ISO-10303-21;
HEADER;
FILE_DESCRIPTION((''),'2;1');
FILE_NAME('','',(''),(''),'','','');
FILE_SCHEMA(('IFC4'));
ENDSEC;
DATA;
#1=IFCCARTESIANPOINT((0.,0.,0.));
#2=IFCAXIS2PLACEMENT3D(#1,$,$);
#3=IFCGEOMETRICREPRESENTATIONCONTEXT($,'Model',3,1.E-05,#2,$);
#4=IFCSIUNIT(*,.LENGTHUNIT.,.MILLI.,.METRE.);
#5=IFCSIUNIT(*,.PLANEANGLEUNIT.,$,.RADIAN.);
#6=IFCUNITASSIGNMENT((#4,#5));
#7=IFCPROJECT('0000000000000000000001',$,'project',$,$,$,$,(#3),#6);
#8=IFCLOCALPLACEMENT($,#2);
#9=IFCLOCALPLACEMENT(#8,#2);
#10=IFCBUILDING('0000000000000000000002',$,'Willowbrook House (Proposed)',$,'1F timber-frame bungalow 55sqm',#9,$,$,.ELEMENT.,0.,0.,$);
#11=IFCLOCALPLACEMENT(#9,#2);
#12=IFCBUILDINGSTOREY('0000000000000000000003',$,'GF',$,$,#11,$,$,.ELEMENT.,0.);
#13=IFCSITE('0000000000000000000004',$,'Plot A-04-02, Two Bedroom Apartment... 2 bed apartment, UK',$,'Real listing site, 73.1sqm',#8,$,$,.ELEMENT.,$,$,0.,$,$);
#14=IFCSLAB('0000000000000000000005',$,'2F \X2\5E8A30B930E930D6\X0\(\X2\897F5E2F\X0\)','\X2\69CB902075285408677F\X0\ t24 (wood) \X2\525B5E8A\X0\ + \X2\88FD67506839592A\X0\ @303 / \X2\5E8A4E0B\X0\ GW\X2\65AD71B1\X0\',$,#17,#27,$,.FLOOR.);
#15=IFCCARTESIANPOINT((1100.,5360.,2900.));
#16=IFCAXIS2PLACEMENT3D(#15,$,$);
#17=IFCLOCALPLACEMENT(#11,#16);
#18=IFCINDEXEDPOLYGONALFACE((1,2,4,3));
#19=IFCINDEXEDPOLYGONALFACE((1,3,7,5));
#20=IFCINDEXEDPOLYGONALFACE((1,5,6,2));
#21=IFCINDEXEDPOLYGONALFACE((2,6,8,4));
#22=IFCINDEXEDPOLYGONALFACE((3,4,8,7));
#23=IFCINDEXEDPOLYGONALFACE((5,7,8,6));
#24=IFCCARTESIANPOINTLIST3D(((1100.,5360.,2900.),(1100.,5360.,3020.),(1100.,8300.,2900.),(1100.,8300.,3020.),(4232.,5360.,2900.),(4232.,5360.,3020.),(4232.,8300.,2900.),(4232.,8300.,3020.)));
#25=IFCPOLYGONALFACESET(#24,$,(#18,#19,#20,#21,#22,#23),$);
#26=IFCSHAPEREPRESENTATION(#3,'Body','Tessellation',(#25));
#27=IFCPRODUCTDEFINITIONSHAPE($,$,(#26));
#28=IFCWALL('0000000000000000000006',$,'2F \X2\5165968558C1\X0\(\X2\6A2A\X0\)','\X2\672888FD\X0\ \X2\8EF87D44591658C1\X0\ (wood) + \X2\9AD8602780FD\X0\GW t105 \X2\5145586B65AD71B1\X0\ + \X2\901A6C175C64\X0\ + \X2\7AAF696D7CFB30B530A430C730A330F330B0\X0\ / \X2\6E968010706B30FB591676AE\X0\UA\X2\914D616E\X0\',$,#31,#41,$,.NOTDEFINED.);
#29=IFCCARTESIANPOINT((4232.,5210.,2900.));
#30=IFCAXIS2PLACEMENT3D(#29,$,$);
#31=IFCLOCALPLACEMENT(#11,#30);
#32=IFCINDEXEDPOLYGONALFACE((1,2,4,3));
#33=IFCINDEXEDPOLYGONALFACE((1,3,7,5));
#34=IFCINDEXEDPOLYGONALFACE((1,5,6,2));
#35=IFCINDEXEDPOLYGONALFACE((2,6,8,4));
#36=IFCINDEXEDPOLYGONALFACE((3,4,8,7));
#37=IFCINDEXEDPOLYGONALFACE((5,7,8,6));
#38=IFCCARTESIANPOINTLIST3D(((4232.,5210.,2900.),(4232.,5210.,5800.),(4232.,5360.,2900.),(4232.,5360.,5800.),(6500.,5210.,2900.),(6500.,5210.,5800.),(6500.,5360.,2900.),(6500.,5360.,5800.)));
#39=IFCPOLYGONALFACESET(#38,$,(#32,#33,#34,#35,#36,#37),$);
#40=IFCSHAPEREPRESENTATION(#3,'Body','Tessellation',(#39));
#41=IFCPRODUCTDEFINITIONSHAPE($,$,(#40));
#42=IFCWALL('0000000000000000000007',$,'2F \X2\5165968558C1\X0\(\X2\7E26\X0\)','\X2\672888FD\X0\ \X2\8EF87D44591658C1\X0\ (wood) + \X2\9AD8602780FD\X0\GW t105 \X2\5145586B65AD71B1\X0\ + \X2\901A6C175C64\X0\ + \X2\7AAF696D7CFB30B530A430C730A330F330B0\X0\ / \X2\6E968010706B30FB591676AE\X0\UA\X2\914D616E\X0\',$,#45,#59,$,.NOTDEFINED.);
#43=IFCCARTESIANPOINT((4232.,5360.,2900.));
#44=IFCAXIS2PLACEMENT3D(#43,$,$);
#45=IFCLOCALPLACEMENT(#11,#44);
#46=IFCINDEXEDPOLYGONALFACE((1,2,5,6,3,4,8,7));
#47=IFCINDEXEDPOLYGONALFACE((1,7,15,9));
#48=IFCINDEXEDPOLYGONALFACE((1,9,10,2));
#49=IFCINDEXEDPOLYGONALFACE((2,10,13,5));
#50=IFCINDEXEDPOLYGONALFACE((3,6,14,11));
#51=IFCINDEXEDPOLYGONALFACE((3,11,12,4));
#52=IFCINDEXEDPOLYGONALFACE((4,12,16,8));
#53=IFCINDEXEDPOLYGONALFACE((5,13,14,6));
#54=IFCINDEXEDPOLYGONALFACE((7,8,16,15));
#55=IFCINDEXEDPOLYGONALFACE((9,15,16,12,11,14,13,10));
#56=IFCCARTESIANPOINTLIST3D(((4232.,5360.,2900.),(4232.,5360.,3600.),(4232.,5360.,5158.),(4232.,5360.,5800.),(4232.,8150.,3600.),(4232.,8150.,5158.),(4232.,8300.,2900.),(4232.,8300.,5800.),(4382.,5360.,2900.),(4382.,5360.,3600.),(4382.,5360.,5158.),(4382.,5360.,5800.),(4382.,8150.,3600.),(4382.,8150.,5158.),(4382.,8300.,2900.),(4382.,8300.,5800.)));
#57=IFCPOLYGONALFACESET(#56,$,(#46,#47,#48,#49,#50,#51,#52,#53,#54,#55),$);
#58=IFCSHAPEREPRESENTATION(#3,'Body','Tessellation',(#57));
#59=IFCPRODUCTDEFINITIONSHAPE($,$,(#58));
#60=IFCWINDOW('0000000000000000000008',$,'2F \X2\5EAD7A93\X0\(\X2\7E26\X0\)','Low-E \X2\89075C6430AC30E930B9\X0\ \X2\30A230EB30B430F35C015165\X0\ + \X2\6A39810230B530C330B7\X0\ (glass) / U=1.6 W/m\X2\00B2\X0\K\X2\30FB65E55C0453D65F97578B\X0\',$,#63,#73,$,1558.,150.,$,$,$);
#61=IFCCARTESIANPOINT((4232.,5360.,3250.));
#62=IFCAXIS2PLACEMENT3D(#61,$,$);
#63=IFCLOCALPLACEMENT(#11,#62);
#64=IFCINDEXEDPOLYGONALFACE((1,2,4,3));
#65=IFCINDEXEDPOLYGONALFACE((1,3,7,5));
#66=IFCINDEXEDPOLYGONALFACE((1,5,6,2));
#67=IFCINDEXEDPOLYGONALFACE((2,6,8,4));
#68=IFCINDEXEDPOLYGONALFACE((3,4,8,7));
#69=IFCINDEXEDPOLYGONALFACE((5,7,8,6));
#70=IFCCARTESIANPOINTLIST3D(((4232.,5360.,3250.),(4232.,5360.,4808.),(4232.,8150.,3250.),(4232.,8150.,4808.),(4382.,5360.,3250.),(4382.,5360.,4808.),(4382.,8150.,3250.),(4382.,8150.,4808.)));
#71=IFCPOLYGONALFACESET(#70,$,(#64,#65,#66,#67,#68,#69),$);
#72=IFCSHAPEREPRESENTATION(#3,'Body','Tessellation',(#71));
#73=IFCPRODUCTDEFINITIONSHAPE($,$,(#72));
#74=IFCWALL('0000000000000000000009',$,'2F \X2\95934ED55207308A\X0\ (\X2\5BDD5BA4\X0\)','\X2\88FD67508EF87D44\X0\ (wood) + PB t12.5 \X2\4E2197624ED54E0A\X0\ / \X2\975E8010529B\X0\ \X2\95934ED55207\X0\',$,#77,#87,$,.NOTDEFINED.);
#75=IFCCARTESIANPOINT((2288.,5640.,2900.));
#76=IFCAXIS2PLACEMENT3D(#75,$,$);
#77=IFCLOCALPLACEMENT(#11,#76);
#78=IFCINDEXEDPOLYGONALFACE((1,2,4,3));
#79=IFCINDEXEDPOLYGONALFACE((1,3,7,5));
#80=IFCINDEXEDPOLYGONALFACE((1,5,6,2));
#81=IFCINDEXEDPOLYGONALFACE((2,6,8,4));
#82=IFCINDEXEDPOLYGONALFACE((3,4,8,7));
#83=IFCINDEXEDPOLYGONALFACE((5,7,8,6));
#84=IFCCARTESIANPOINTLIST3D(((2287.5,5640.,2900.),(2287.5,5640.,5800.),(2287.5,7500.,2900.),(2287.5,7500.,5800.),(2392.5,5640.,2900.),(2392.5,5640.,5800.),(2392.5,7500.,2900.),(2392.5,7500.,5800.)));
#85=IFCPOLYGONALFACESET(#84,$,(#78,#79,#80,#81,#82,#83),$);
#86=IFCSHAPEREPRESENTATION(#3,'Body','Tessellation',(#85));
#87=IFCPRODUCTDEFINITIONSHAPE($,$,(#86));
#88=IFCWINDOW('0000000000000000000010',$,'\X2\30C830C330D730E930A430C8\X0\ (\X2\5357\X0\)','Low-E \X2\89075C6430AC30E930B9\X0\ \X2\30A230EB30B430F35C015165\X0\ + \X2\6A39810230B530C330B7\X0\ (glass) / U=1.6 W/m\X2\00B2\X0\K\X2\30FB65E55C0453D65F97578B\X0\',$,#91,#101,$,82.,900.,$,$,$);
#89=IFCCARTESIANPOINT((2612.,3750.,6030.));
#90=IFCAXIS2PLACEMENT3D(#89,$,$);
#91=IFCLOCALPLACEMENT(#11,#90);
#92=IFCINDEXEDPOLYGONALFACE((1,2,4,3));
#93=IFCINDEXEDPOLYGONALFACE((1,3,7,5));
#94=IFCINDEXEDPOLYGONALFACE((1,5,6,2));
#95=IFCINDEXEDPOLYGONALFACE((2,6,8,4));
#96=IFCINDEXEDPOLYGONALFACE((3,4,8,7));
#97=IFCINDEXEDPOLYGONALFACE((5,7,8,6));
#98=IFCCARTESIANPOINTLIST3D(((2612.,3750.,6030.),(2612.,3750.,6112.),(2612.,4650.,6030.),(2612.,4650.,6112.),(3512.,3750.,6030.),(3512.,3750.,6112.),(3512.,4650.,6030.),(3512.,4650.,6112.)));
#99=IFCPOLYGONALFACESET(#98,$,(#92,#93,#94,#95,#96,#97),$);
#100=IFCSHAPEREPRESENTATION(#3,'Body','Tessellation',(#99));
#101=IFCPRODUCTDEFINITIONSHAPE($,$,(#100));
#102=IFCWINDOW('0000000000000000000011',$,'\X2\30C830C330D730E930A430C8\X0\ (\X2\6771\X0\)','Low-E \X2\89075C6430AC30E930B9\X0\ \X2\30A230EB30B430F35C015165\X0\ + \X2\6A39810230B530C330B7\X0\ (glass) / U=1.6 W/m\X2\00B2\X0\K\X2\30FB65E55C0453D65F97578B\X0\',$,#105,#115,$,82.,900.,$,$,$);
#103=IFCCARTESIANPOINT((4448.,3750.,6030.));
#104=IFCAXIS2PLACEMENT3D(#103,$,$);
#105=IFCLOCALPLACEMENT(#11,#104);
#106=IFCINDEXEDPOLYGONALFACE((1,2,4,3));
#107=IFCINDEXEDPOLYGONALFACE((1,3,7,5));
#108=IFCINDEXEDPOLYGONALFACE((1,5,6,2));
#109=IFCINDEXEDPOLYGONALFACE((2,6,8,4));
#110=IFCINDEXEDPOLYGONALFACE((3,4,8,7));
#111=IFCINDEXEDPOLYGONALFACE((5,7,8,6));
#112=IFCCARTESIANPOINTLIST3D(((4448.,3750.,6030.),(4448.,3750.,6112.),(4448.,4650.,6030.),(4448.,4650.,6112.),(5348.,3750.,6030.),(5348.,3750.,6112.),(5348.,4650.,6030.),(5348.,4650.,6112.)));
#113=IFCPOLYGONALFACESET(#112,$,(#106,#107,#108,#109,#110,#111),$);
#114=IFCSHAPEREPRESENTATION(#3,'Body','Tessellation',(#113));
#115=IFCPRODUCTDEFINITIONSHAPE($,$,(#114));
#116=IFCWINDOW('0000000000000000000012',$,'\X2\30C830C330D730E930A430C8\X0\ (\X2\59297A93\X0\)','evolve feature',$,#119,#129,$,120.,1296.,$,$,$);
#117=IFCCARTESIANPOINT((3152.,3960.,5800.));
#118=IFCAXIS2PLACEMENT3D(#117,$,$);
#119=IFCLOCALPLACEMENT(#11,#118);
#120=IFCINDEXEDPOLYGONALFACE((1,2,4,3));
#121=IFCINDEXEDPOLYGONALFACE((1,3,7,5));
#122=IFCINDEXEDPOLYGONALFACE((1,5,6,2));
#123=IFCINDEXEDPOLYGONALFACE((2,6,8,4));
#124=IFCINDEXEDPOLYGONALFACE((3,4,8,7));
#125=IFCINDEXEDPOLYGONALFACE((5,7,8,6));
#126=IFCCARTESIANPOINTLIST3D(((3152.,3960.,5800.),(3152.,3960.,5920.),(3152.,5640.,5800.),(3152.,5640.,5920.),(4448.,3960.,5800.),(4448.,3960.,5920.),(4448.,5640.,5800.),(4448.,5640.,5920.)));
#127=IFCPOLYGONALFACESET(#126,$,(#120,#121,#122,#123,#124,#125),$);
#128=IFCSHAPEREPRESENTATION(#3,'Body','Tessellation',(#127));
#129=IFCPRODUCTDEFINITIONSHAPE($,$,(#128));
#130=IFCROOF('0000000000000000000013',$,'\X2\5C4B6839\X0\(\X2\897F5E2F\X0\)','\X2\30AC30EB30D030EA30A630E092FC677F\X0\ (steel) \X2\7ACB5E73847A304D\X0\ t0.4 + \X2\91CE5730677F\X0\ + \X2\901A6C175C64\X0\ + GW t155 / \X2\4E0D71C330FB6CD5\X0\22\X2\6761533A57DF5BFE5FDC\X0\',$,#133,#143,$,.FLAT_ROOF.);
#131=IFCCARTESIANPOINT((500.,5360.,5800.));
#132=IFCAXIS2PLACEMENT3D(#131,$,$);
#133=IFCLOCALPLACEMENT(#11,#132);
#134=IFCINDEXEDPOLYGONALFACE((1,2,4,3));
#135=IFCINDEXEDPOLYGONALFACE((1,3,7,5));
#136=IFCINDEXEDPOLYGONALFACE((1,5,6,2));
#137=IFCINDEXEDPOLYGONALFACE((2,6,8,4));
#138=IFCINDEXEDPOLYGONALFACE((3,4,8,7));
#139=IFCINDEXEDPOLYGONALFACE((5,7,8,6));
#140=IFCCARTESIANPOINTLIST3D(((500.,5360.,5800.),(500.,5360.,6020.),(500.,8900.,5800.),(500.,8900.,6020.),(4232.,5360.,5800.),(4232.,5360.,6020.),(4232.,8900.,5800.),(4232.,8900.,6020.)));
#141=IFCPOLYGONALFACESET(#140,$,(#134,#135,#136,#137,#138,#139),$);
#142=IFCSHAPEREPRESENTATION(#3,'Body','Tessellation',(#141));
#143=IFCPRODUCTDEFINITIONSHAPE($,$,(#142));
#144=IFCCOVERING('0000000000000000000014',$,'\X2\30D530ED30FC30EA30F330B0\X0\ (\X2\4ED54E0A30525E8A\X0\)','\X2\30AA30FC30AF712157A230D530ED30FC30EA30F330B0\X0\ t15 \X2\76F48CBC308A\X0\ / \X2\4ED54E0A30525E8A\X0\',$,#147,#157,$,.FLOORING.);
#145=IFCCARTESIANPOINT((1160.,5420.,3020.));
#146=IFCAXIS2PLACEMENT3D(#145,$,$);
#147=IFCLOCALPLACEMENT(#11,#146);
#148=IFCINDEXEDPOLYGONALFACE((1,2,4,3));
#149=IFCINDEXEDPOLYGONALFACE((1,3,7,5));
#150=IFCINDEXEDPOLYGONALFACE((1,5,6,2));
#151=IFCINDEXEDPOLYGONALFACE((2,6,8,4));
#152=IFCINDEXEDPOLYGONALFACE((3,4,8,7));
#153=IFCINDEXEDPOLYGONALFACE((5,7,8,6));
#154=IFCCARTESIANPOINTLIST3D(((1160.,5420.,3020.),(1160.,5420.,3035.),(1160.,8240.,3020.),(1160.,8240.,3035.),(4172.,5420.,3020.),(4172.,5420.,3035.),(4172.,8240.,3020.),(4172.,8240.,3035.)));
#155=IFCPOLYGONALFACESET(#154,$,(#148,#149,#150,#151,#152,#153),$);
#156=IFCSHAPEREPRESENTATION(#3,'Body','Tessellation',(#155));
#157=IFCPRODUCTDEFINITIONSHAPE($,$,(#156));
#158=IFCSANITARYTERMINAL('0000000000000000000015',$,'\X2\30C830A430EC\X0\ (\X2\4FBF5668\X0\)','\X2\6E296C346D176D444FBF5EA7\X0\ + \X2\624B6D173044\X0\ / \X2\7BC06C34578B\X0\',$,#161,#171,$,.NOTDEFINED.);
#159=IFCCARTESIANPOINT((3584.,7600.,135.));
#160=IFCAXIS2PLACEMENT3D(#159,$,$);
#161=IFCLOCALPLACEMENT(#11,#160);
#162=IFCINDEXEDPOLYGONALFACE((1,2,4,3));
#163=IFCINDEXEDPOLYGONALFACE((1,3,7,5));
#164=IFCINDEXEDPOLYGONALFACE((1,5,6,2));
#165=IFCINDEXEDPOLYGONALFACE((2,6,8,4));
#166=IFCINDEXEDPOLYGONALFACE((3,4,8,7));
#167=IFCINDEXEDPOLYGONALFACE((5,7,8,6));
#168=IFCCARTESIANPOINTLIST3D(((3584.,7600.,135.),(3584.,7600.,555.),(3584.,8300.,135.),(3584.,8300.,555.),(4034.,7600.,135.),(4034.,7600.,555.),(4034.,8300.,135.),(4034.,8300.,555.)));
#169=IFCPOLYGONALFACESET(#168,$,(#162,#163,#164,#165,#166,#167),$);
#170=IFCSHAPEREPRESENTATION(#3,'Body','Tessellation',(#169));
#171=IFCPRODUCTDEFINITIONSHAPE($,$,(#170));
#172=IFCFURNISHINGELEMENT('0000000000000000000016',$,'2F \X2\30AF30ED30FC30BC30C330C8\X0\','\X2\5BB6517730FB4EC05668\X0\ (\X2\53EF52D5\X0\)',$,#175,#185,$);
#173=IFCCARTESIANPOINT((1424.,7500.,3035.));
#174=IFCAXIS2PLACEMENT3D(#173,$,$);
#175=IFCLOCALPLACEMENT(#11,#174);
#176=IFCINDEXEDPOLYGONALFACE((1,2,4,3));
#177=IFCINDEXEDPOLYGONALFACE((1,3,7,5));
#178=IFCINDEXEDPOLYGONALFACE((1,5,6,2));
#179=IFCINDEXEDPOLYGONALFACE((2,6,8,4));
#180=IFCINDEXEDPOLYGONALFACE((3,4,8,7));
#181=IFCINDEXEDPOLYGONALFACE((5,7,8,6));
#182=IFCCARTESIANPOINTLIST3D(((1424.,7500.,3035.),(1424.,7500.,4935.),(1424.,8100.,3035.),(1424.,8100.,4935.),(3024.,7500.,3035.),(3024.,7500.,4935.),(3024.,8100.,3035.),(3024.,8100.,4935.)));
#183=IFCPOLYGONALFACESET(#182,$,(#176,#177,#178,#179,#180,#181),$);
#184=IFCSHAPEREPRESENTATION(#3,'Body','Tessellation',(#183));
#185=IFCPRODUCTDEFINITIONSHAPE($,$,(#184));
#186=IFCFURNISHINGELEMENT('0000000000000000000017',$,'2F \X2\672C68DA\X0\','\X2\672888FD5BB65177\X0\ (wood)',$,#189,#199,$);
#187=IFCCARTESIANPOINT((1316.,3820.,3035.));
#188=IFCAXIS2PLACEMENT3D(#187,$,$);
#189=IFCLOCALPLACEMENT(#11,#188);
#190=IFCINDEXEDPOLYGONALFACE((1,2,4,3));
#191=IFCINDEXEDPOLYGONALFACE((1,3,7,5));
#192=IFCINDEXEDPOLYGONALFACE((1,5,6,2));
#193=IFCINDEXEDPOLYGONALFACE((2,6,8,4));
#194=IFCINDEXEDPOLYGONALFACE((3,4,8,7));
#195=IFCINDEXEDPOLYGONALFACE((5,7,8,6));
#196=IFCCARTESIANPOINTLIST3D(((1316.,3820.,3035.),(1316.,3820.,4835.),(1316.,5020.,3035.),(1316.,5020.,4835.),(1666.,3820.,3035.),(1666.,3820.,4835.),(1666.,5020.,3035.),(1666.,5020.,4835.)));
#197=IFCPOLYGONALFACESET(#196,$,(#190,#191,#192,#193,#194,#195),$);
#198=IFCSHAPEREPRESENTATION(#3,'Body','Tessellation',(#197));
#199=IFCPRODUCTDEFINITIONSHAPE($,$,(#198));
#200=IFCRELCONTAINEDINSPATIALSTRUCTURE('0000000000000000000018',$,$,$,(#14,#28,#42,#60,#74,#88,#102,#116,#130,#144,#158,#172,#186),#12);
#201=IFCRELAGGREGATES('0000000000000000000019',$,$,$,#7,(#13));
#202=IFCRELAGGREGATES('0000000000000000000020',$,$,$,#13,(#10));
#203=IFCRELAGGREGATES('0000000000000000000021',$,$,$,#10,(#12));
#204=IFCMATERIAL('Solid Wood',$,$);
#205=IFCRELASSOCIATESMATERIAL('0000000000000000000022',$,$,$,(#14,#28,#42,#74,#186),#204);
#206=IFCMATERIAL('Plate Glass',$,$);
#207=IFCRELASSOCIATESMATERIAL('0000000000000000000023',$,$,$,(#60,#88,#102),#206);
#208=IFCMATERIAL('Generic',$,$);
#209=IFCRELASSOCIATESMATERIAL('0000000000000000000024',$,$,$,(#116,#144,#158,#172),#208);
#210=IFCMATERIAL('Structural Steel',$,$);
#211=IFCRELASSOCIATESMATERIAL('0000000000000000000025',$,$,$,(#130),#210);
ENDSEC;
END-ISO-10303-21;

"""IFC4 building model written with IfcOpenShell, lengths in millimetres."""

from ifc_helpers import new_model, si_unit, frame, frame_2d, origin, place, context, project, spatial, rectangle, extrude, material, element, fill, save


model = new_model("IFC4")

# Units and contexts
model_context = context("Model", 3, precision=1e-05, world=origin())
ifc_project = project(units=[si_unit("LENGTHUNIT", "METRE", prefix="MILLI"), si_unit("PLANEANGLEUNIT", "RADIAN")], contexts=[model_context])

# Site, building, storey
site_placement = place(None, origin())
site = spatial("IfcSite", under=ifc_project, at=site_placement, Name="Plot A-04-02, Two Bedroom Apartment... 2 bed apartment, UK", ObjectType="Real listing site, 73.1sqm", CompositionType="ELEMENT", RefElevation=0.0)
building_placement = place(site_placement, origin())
building = spatial("IfcBuilding", under=site, at=building_placement, Name="Willowbrook House (Proposed)", ObjectType="1F timber-frame bungalow 55sqm", CompositionType="ELEMENT", ElevationOfRefHeight=0.0, ElevationOfTerrain=0.0)
storey_placement = place(building_placement, origin())
storey = spatial("IfcBuildingStorey", under=building, at=storey_placement, Name="GF", CompositionType="ELEMENT", Elevation=0.0)

# Slab
ifc_material_1 = material(Name="Solid Wood")
slab_placement = place(storey_placement, frame((1100.0, 5360.0, 2900.0)))
element("IfcSlab", 1, at=slab_placement, inside=storey, material=ifc_material_1, Name="2F 床スラブ(西帯)", Description="構造用合板 t24 (wood) 剛床 + 製材根太 @303 / 床下 GW断熱", PredefinedType="FLOOR", context=model_context, shape_type="SweptSolid", body=[
    extrude(rectangle(XDim=3132.0, YDim=2940.0, at=frame_2d((1566.0, 1470.0))), frame((1100.0, 5360.0, 2900.0)), (0.0, 0.0, 1.0), 120.0),
])

# Shared definitions
ifc_material_2 = material(Name="Plate Glass")

# Wall
wall_1_placement = place(storey_placement, frame((4232.0, 5210.0, 2900.0)))
element("IfcWall", 2, at=wall_1_placement, inside=storey, material=ifc_material_1, Name="2F 入隅壁(横)", Description="木製 軸組外壁 (wood) + 高性能GW t105 充填断熱 + 通気層 + 窯業系サイディング / 準耐火・外皮UA配慮", PredefinedType="NOTDEFINED", context=model_context, shape_type="SweptSolid", body=[
    extrude(rectangle(XDim=2268.0, YDim=150.0, at=frame_2d((1134.0, 75.0))), frame((4232.0, 5210.0, 2900.0)), (0.0, 0.0, 1.0), 2900.0),
])

# Wall, opening, window
wall_2_placement = place(storey_placement, frame((4232.0, 5360.0, 2900.0)))
wall_2 = element("IfcWall", 3, at=wall_2_placement, inside=storey, material=ifc_material_1, Name="2F 入隅壁(縦)", Description="木製 軸組外壁 (wood) + 高性能GW t105 充填断熱 + 通気層 + 窯業系サイディング / 準耐火・外皮UA配慮", PredefinedType="NOTDEFINED", context=model_context, shape_type="SweptSolid", body=[
    extrude(rectangle(XDim=150.0, YDim=2940.0, at=frame_2d((75.0, 1470.0))), frame((4232.0, 5360.0, 2900.0)), (0.0, 0.0, 1.0), 2900.0),
])
opening_1_placement = place(storey_placement, frame((4232.0, 5360.0, 3250.0)))
opening_1 = element("IfcOpeningElement", 4, at=opening_1_placement, cuts=wall_2, PredefinedType="NOTDEFINED", context=model_context, shape_type="SweptSolid", body=[
    extrude(rectangle(XDim=150.0, YDim=2790.0, at=frame_2d((75.0, 1395.0))), frame((4232.0, 5360.0, 3250.0)), (0.0, 0.0, 1.0), 1558.0),
])
window_1_placement = place(storey_placement, frame((4232.0, 5360.0, 3250.0)))
window_1 = element("IfcWindow", 5, at=window_1_placement, inside=storey, material=ifc_material_2, Name="2F 庭窓(縦)", Description="Low-E 複層ガラス アルゴン封入 + 樹脂サッシ (glass) / U=1.6 W/m²K・日射取得型", OverallHeight=1558.0, OverallWidth=150.0, context=model_context, shape_type="SweptSolid", body=[
    extrude(rectangle(XDim=150.0, YDim=2790.0, at=frame_2d((75.0, 1395.0))), frame((4232.0, 5360.0, 3250.0)), (0.0, 0.0, 1.0), 1558.0),
])
fill(opening_1, window_1)

# Wall
wall_3_placement = place(storey_placement, frame((2288.0, 5640.0, 2900.0)))
element("IfcWall", 6, at=wall_3_placement, inside=storey, material=ifc_material_1, Name="2F 間仕切り (寝室)", Description="製材軸組 (wood) + PB t12.5 両面仕上 / 非耐力 間仕切", PredefinedType="NOTDEFINED", context=model_context, shape_type="SweptSolid", body=[
    extrude(rectangle(XDim=105.0, YDim=1860.0, at=frame_2d((52.0, 930.0))), frame((2288.0, 5640.0, 2900.0)), (0.0, 0.0, 1.0), 2900.0),
])

# Windows
window_2_placement = place(storey_placement, frame((2612.0, 3750.0, 6030.0)))
element("IfcWindow", 7, at=window_2_placement, inside=storey, material=ifc_material_2, Name="トップライト (南)", Description="Low-E 複層ガラス アルゴン封入 + 樹脂サッシ (glass) / U=1.6 W/m²K・日射取得型", OverallHeight=82.0, OverallWidth=900.0, context=model_context, shape_type="SweptSolid", body=[
    extrude(rectangle(XDim=900.0, YDim=900.0, at=frame_2d((450.0, 450.0))), frame((2612.0, 3750.0, 6030.0)), (0.0, 0.0, 1.0), 82.0),
])
window_3_placement = place(storey_placement, frame((4448.0, 3750.0, 6030.0)))
element("IfcWindow", 8, at=window_3_placement, inside=storey, material=ifc_material_2, Name="トップライト (東)", Description="Low-E 複層ガラス アルゴン封入 + 樹脂サッシ (glass) / U=1.6 W/m²K・日射取得型", OverallHeight=82.0, OverallWidth=900.0, context=model_context, shape_type="SweptSolid", body=[
    extrude(rectangle(XDim=900.0, YDim=900.0, at=frame_2d((450.0, 450.0))), frame((4448.0, 3750.0, 6030.0)), (0.0, 0.0, 1.0), 82.0),
])
ifc_material_3 = material(Name="Generic")
window_4_placement = place(storey_placement, frame((3152.0, 3960.0, 5800.0)))
element("IfcWindow", 9, at=window_4_placement, inside=storey, material=ifc_material_3, Name="トップライト (天窓)", Description="evolve feature", OverallHeight=120.0, OverallWidth=1296.0, context=model_context, shape_type="SweptSolid", body=[
    extrude(rectangle(XDim=1296.0, YDim=1680.0, at=frame_2d((648.0, 840.0))), frame((3152.0, 3960.0, 5800.0)), (0.0, 0.0, 1.0), 120.0),
])

# Roof
ifc_material_4 = material(Name="Structural Steel")
for number, where, name in (
    (10, (500.0, 5360.0, 5800.0), "屋根(西帯)"),
):
    element("IfcRoof", number, at=place(storey_placement, frame(where)), inside=storey, material=ifc_material_4, Name=name, Description="ガルバリウム鋼板 (steel) 立平葺き t0.4 + 野地板 + 通気層 + GW t155 / 不燃・法22条区域対応", PredefinedType="FLAT_ROOF", context=model_context, shape_type="SweptSolid", body=[
        extrude(rectangle(XDim=3732.0, YDim=3540.0, at=frame_2d((1866.0, 1770.0))), frame((500.0, 5360.0, 5800.0)), (0.0, 0.0, 1.0), 220.0),
    ])

# Covering
covering_placement = place(storey_placement, frame((1160.0, 5420.0, 3020.0)))
element("IfcCovering", 11, at=covering_placement, inside=storey, material=ifc_material_3, Name="フローリング (仕上げ床)", Description="オーク無垢フローリング t15 直貼り / 仕上げ床", PredefinedType="FLOORING", context=model_context, shape_type="SweptSolid", body=[
    extrude(rectangle(XDim=3012.0, YDim=2820.0, at=frame_2d((1506.0, 1410.0))), frame((1160.0, 5420.0, 3020.0)), (0.0, 0.0, 1.0), 15.0),
])

# Sanitary terminal
sanitary_terminal_placement = place(storey_placement, frame((3584.0, 7600.0, 135.0)))
element("IfcSanitaryTerminal", 12, at=sanitary_terminal_placement, inside=storey, material=ifc_material_3, Name="トイレ (便器)", Description="温水洗浄便座 + 手洗い / 節水型", PredefinedType="NOTDEFINED", context=model_context, shape_type="SweptSolid", body=[
    extrude(rectangle(XDim=450.0, YDim=700.0, at=frame_2d((225.0, 350.0))), frame((3584.0, 7600.0, 135.0)), (0.0, 0.0, 1.0), 420.0),
])

# Furnishing elements
furnishing_1_placement = place(storey_placement, frame((1424.0, 7500.0, 3035.0)))
element("IfcFurnishingElement", 13, at=furnishing_1_placement, inside=storey, material=ifc_material_3, Name="2F クローゼット", Description="家具・什器 (可動)", context=model_context, shape_type="SweptSolid", body=[
    extrude(rectangle(XDim=1600.0, YDim=600.0, at=frame_2d((800.0, 300.0))), frame((1424.0, 7500.0, 3035.0)), (0.0, 0.0, 1.0), 1900.0),
])
furnishing_2_placement = place(storey_placement, frame((1316.0, 3820.0, 3035.0)))
element("IfcFurnishingElement", 14, at=furnishing_2_placement, inside=storey, material=ifc_material_1, Name="2F 本棚", Description="木製家具 (wood)", context=model_context, shape_type="SweptSolid", body=[
    extrude(rectangle(XDim=350.0, YDim=1200.0, at=frame_2d((175.0, 600.0))), frame((1316.0, 3820.0, 3035.0)), (0.0, 0.0, 1.0), 1800.0),
])

save(model, "model.ifc")
